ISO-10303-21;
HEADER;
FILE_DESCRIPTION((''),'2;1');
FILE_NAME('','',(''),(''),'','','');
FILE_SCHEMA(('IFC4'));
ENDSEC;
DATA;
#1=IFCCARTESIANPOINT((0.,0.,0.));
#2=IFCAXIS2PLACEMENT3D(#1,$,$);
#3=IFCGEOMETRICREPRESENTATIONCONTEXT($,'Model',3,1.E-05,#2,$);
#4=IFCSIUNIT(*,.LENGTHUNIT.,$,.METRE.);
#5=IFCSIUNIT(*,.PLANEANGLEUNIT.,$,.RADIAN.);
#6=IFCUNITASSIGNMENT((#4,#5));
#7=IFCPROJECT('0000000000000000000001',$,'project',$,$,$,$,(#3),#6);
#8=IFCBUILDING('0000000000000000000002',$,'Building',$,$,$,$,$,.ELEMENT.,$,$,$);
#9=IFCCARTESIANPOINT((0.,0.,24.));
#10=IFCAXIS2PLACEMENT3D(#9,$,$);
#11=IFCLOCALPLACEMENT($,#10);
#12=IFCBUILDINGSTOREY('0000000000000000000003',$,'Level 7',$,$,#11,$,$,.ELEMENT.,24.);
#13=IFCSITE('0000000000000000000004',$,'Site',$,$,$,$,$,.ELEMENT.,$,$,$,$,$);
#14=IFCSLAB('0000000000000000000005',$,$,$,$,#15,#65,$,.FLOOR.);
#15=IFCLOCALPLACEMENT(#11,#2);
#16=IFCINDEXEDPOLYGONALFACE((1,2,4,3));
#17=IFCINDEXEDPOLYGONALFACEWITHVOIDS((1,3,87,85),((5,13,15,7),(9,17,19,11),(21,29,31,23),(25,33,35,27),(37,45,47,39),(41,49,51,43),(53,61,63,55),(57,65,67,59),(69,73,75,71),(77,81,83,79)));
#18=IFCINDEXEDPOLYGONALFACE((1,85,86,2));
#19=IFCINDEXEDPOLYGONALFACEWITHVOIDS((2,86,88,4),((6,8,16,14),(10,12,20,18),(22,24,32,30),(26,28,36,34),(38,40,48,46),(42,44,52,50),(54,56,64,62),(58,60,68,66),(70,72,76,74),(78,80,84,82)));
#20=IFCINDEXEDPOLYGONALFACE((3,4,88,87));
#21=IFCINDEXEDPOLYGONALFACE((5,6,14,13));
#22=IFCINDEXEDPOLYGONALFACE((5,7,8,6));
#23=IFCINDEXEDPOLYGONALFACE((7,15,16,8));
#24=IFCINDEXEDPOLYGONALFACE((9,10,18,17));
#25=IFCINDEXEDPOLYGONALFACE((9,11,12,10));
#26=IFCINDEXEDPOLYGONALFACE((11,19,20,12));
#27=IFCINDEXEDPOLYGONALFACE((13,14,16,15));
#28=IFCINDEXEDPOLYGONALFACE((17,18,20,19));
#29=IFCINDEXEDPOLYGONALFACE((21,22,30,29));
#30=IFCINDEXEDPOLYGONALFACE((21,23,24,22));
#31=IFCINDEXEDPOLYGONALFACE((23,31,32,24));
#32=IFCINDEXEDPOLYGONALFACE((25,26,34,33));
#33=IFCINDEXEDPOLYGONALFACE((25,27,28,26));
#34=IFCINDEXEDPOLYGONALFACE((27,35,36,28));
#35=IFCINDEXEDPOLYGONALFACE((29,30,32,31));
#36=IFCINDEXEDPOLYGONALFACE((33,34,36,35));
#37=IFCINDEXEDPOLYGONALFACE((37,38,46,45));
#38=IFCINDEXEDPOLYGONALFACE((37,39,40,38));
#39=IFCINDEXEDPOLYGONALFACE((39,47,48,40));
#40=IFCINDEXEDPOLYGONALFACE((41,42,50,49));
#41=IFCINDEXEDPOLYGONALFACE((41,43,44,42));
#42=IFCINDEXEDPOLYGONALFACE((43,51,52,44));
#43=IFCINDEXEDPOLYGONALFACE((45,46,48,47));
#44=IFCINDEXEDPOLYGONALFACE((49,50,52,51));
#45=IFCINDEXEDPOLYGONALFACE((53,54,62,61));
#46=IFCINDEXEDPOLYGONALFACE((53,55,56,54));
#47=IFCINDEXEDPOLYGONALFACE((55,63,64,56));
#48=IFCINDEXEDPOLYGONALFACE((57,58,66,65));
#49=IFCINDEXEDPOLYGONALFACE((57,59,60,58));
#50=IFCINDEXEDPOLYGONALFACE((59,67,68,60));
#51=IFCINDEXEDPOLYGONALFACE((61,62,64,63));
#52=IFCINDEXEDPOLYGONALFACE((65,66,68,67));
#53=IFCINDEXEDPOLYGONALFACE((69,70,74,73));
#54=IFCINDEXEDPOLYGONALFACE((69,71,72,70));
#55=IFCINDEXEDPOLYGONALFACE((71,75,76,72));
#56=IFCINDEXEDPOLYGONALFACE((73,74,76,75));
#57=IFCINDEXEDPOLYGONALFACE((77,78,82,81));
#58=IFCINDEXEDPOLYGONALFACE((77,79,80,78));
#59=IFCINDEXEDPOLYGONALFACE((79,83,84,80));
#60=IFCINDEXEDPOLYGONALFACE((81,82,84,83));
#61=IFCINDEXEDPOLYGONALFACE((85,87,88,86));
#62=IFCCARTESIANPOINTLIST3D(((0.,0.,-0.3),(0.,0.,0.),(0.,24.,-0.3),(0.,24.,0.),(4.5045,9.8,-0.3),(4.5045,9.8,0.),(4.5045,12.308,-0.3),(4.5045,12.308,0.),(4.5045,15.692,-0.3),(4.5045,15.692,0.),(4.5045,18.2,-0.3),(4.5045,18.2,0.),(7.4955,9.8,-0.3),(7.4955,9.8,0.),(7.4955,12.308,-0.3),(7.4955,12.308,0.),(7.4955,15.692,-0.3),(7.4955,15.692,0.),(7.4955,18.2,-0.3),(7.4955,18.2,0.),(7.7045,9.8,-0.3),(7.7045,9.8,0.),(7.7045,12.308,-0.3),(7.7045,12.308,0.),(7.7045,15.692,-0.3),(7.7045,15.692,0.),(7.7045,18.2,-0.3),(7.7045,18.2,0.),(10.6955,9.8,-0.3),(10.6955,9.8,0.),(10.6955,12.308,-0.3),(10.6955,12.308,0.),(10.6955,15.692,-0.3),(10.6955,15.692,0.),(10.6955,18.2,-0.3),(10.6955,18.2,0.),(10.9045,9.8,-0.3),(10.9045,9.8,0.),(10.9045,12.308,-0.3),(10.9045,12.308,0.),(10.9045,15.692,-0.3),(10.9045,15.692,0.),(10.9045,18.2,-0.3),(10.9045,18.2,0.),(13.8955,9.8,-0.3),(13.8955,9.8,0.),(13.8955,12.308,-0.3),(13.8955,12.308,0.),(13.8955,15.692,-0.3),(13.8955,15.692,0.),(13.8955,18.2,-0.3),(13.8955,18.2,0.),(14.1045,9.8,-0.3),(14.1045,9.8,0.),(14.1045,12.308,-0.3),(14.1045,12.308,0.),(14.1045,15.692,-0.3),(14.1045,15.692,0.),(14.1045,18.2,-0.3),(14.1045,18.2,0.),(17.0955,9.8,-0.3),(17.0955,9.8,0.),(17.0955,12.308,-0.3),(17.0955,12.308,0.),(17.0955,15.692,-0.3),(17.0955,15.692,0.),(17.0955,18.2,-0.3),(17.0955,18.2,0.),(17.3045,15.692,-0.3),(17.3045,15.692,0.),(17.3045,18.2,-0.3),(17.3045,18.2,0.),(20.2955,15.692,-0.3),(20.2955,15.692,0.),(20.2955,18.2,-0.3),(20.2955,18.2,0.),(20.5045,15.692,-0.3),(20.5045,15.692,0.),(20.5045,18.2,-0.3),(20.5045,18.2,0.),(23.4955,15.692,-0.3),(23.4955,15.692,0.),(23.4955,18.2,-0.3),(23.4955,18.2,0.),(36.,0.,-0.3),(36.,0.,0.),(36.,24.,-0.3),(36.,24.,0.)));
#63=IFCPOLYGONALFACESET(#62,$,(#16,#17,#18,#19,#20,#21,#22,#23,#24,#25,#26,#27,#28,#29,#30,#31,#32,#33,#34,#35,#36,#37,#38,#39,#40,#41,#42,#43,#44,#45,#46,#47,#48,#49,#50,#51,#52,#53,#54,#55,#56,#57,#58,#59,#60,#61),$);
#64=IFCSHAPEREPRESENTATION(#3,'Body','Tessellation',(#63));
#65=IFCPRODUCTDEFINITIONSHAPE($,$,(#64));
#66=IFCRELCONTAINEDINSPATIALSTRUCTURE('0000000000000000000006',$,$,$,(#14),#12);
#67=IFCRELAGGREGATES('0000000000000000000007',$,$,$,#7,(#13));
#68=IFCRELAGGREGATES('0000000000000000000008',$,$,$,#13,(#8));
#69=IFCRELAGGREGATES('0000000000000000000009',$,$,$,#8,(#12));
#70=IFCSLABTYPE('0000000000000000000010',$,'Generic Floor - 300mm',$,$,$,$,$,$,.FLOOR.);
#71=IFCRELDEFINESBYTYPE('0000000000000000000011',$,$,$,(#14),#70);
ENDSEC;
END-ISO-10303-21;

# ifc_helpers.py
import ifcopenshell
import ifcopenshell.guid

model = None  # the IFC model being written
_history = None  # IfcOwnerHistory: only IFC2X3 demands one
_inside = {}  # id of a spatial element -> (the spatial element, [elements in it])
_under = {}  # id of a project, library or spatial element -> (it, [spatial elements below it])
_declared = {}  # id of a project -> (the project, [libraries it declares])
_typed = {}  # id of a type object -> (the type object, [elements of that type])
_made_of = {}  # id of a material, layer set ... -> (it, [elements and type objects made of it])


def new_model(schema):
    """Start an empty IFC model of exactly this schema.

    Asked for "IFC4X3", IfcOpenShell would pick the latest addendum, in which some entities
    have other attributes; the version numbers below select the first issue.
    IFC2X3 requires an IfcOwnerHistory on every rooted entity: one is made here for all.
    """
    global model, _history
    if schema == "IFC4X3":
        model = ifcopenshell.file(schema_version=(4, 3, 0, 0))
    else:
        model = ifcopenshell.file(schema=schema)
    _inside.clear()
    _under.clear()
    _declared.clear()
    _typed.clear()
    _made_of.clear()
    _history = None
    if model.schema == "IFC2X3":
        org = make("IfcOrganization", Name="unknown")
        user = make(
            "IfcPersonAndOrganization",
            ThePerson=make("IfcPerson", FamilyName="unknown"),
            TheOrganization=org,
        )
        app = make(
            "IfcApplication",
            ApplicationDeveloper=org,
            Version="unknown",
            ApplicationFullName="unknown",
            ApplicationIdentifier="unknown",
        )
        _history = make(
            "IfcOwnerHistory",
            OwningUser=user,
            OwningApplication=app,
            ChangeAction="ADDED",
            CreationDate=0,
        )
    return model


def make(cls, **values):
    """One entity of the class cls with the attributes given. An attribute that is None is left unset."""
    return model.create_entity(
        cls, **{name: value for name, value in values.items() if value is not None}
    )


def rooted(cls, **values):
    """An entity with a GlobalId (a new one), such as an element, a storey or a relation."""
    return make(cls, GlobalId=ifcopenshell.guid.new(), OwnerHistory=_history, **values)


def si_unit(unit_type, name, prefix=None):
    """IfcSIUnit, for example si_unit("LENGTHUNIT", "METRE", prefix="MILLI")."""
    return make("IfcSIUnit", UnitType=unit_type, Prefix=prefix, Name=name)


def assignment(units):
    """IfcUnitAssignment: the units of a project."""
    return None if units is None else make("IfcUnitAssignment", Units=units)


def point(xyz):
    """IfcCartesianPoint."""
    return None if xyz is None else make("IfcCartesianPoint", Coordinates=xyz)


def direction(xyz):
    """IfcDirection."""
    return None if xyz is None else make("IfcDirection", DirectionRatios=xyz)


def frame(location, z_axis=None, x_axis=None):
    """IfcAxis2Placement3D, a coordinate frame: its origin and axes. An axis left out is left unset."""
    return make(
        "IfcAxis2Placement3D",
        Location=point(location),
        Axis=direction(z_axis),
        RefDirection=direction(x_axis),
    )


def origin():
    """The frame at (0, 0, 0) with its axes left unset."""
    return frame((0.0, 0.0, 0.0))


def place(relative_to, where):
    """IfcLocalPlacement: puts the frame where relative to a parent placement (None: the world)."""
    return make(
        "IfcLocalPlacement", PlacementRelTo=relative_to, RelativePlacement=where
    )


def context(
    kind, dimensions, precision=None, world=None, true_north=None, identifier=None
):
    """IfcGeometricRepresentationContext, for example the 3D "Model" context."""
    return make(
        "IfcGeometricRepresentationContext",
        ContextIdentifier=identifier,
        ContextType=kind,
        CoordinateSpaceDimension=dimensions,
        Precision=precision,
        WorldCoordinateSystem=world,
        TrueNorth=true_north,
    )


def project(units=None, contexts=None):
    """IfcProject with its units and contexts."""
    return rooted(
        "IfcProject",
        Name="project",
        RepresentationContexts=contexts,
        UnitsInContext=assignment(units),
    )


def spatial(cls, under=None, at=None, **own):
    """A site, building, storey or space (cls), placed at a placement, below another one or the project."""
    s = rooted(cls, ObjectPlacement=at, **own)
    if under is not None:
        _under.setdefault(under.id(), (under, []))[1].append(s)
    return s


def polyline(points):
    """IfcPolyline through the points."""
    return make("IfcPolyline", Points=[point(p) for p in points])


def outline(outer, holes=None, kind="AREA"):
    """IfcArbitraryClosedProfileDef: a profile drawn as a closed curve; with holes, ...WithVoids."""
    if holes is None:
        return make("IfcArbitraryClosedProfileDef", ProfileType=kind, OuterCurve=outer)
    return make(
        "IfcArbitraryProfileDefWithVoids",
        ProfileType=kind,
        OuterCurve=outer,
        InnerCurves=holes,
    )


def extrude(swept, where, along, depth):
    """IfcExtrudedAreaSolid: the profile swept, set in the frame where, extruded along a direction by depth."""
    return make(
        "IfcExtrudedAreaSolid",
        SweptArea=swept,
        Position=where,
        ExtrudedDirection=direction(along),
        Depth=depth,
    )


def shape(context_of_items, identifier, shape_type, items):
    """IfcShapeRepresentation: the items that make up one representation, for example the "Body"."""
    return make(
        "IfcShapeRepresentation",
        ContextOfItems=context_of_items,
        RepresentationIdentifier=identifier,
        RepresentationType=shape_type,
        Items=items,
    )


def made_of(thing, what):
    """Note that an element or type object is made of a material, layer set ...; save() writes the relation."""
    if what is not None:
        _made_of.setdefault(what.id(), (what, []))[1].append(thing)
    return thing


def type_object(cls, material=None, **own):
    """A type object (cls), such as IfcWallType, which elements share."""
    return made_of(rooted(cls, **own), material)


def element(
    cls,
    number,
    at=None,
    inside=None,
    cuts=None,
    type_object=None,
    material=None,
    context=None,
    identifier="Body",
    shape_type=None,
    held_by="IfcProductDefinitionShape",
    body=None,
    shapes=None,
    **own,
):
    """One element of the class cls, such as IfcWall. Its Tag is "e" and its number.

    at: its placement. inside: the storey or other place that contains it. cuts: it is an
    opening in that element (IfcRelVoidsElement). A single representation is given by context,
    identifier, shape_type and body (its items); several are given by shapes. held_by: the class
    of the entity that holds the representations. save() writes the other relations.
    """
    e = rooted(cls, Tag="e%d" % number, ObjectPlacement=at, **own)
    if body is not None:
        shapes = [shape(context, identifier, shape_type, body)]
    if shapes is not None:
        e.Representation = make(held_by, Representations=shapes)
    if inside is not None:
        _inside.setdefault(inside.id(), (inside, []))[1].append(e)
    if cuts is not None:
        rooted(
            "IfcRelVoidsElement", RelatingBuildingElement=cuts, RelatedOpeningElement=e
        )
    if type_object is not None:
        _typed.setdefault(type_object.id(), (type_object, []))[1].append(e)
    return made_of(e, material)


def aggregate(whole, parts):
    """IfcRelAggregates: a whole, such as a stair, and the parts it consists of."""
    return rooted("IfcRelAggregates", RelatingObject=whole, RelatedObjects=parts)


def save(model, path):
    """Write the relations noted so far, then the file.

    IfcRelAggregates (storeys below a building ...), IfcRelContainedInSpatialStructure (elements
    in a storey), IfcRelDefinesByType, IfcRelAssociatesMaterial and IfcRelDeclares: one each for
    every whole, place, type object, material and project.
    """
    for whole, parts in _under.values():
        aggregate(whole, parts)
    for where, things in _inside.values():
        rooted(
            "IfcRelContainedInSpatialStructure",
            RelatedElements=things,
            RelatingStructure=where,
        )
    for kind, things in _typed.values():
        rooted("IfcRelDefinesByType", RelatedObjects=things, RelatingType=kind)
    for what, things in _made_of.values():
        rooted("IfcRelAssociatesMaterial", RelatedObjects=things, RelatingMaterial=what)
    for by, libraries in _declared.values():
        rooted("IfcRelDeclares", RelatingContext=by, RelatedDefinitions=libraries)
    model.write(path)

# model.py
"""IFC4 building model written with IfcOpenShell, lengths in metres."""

from ifc_helpers import new_model, si_unit, frame, origin, place, context, project, spatial, polyline, outline, extrude, type_object, element, save


model = new_model("IFC4")

# Units and contexts
model_context = context("Model", 3, precision=1e-05, world=origin())
ifc_project = project(units=[si_unit("LENGTHUNIT", "METRE"), si_unit("PLANEANGLEUNIT", "RADIAN")], contexts=[model_context])

# Site, building, storey
site = spatial("IfcSite", under=ifc_project, Name="Site", CompositionType="ELEMENT")
building = spatial("IfcBuilding", under=site, Name="Building", CompositionType="ELEMENT")
storey_placement = place(None, frame((0.0, 0.0, 24.0)))
storey = spatial("IfcBuildingStorey", under=building, at=storey_placement, Name="Level 7", CompositionType="ELEMENT", Elevation=24.0)

# Slab, openings
slab_type = type_object("IfcSlabType", Name="Generic Floor - 300mm", PredefinedType="FLOOR")
slab_placement = place(None, frame((0.0, 0.0, 24.0)))
slab = element("IfcSlab", 1, at=slab_placement, inside=storey, type_object=slab_type, PredefinedType="FLOOR", context=model_context, shape_type="SweptSolid", body=[
    extrude(outline(polyline([(0.0, 0.0), (36.0, 0.0), (36.0, 24.0), (0.0, 24.0), (0.0, 0.0)])), origin(), (0.0, 0.0, -1.0), 0.3),
])
opening_1_placement = place(None, frame((0.0, 0.0, 24.001)))
element("IfcOpeningElement", 2, at=opening_1_placement, cuts=slab, PredefinedType="OPENING", context=model_context, shape_type="SweptSolid", body=[
    extrude(outline(polyline([(4.5045, 9.8), (7.4955, 9.8), (7.4955, 12.308), (4.5045, 12.308), (4.5045, 9.8)])), origin(), (0.0, 0.0, -1.0), 0.302),
])
opening_2_placement = place(None, frame((0.0, 0.0, 24.001)))
element("IfcOpeningElement", 3, at=opening_2_placement, cuts=slab, PredefinedType="OPENING", context=model_context, shape_type="SweptSolid", body=[
    extrude(outline(polyline([(7.7045, 9.8), (10.6955, 9.8), (10.6955, 12.308), (7.7045, 12.308), (7.7045, 9.8)])), origin(), (0.0, 0.0, -1.0), 0.302),
])
opening_3_placement = place(None, frame((0.0, 0.0, 24.001)))
element("IfcOpeningElement", 4, at=opening_3_placement, cuts=slab, PredefinedType="OPENING", context=model_context, shape_type="SweptSolid", body=[
    extrude(outline(polyline([(10.9045, 9.8), (13.8955, 9.8), (13.8955, 12.308), (10.9045, 12.308), (10.9045, 9.8)])), origin(), (0.0, 0.0, -1.0), 0.302),
])
opening_4_placement = place(None, frame((0.0, 0.0, 24.001)))
element("IfcOpeningElement", 5, at=opening_4_placement, cuts=slab, PredefinedType="OPENING", context=model_context, shape_type="SweptSolid", body=[
    extrude(outline(polyline([(14.1045, 9.8), (17.0955, 9.8), (17.0955, 12.308), (14.1045, 12.308), (14.1045, 9.8)])), origin(), (0.0, 0.0, -1.0), 0.302),
])
opening_5_placement = place(None, frame((0.0, 0.0, 24.001)))
element("IfcOpeningElement", 6, at=opening_5_placement, cuts=slab, PredefinedType="OPENING", context=model_context, shape_type="SweptSolid", body=[
    extrude(outline(polyline([(7.4955, 18.2), (4.5045, 18.2), (4.5045, 15.692), (7.4955, 15.692), (7.4955, 18.2)])), origin(), (0.0, 0.0, -1.0), 0.302),
])
opening_6_placement = place(None, frame((0.0, 0.0, 24.001)))
element("IfcOpeningElement", 7, at=opening_6_placement, cuts=slab, PredefinedType="OPENING", context=model_context, shape_type="SweptSolid", body=[
    extrude(outline(polyline([(10.6955, 18.2), (7.7045, 18.2), (7.7045, 15.692), (10.6955, 15.692), (10.6955, 18.2)])), origin(), (0.0, 0.0, -1.0), 0.302),
])
opening_7_placement = place(None, frame((0.0, 0.0, 24.001)))
element("IfcOpeningElement", 8, at=opening_7_placement, cuts=slab, PredefinedType="OPENING", context=model_context, shape_type="SweptSolid", body=[
    extrude(outline(polyline([(13.8955, 18.2), (10.9045, 18.2), (10.9045, 15.692), (13.8955, 15.692), (13.8955, 18.2)])), origin(), (0.0, 0.0, -1.0), 0.302),
])
opening_8_placement = place(None, frame((0.0, 0.0, 24.001)))
element("IfcOpeningElement", 9, at=opening_8_placement, cuts=slab, PredefinedType="OPENING", context=model_context, shape_type="SweptSolid", body=[
    extrude(outline(polyline([(17.0955, 18.2), (14.1045, 18.2), (14.1045, 15.692), (17.0955, 15.692), (17.0955, 18.2)])), origin(), (0.0, 0.0, -1.0), 0.302),
])
opening_9_placement = place(None, frame((0.0, 0.0, 24.001)))
element("IfcOpeningElement", 10, at=opening_9_placement, cuts=slab, PredefinedType="OPENING", context=model_context, shape_type="SweptSolid", body=[
    extrude(outline(polyline([(20.2955, 18.2), (17.3045, 18.2), (17.3045, 15.692), (20.2955, 15.692), (20.2955, 18.2)])), origin(), (0.0, 0.0, -1.0), 0.302),
])
opening_10_placement = place(None, frame((0.0, 0.0, 24.001)))
element("IfcOpeningElement", 11, at=opening_10_placement, cuts=slab, PredefinedType="OPENING", context=model_context, shape_type="SweptSolid", body=[
    extrude(outline(polyline([(23.4955, 18.2), (20.5045, 18.2), (20.5045, 15.692), (23.4955, 15.692), (23.4955, 18.2)])), origin(), (0.0, 0.0, -1.0), 0.302),
])

save(model, "model.ifc")
